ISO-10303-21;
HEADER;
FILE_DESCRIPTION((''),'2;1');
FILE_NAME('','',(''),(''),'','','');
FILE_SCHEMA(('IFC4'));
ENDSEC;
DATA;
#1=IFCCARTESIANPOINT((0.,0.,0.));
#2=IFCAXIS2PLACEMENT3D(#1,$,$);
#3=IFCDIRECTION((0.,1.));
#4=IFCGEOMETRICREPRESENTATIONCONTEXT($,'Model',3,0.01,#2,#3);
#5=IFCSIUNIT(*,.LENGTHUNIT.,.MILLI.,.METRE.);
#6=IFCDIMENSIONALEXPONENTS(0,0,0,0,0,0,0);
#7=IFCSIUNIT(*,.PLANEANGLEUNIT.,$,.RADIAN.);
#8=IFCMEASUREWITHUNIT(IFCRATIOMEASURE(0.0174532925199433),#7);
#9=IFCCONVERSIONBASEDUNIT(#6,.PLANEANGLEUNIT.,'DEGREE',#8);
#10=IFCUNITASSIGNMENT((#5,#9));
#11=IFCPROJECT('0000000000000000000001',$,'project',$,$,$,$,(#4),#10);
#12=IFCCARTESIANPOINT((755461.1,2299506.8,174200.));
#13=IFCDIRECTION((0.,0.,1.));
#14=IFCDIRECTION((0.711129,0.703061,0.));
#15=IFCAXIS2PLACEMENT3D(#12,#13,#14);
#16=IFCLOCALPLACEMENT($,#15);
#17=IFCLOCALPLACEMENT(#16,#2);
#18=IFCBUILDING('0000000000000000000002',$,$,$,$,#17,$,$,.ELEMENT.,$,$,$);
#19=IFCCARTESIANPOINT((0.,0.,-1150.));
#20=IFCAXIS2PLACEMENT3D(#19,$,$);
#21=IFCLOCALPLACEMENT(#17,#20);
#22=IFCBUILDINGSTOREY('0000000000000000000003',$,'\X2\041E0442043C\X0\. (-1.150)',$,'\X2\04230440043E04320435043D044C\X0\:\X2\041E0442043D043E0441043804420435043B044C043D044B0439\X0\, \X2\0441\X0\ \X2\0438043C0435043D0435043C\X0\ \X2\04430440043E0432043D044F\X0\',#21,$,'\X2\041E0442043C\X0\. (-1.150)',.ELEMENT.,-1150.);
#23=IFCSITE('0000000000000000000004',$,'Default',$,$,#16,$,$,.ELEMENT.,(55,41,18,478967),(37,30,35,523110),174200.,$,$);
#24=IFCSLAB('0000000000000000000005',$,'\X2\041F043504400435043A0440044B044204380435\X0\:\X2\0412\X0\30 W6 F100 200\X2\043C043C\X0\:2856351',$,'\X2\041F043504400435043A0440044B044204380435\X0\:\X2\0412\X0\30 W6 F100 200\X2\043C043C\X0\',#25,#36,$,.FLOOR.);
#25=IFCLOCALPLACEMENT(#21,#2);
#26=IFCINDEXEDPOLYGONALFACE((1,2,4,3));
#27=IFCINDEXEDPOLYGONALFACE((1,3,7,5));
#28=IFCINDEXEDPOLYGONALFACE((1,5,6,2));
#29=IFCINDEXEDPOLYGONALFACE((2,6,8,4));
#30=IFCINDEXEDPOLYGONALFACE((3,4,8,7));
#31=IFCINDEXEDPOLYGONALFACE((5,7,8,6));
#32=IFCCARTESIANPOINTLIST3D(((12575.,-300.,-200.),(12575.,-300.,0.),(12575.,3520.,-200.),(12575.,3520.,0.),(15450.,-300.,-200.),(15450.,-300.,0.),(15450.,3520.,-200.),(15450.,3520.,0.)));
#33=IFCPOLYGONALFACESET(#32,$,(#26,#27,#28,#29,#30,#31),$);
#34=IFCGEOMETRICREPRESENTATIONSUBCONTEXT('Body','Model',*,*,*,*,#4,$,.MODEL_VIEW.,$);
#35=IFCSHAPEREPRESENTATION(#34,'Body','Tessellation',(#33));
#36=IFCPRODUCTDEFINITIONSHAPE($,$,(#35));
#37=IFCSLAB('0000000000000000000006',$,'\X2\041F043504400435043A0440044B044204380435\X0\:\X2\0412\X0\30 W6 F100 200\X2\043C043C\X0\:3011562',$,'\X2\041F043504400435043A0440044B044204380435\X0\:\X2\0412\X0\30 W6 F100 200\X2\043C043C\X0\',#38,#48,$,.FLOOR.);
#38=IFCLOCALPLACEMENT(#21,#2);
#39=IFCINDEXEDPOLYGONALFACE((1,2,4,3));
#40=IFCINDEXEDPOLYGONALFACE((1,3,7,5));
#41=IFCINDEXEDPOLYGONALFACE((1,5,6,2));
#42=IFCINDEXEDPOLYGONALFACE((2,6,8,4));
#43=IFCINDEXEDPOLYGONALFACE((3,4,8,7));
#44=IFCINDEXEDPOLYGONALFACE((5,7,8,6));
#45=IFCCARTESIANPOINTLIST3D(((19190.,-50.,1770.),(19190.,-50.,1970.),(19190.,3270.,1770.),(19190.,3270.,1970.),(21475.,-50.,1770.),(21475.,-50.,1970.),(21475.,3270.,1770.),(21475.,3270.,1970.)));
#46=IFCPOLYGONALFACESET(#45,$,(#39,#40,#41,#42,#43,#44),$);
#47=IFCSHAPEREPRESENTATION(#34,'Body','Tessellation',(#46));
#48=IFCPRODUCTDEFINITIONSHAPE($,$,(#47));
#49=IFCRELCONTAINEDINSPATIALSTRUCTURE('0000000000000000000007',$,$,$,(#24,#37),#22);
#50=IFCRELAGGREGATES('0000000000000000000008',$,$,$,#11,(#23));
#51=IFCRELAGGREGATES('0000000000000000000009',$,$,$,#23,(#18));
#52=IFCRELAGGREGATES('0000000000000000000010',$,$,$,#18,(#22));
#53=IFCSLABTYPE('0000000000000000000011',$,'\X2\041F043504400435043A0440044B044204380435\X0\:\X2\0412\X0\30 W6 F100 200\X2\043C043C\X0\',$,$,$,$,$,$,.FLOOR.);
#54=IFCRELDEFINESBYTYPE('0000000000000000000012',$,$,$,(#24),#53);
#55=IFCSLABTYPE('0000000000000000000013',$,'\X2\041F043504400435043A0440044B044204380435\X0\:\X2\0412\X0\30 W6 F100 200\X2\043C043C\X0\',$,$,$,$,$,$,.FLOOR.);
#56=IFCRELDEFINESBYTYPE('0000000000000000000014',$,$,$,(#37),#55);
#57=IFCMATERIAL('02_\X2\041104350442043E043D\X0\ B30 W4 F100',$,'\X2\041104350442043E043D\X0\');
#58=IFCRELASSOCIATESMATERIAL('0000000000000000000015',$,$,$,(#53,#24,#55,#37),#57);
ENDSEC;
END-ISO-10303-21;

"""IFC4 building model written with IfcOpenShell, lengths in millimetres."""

from ifc_helpers import new_model, entity, si_unit, converted_unit, direction, frame, origin, place, context, subcontext, project, spatial, indexed_curve, outline, extrude, material, type_object, element, save


model = new_model("IFC4")

# Units and contexts
model_context = context("Model", 3, precision=0.01, world=origin(), true_north=direction((0.0, 1.0)))
body_context = subcontext(model_context, "Body", "Model", "MODEL_VIEW")
ifc_project = project(units=[si_unit("LENGTHUNIT", "METRE", prefix="MILLI"), converted_unit("PLANEANGLEUNIT", "DEGREE", entity("IfcRatioMeasure", 0.0174532925199433), si_unit("PLANEANGLEUNIT", "RADIAN"), dimensions=[0, 0, 0, 0, 0, 0, 0])], contexts=[model_context])

# Site, building, storey
site_placement = place(None, frame((755461.1, 2299506.8, 174200.0), z_axis=(0.0, 0.0, 1.0), x_axis=(0.711129, 0.703061, 0.0)))
site = spatial("IfcSite", under=ifc_project, at=site_placement, Name="Default", CompositionType="ELEMENT", RefLatitude=(55, 41, 18, 478967), RefLongitude=(37, 30, 35, 523110), RefElevation=174200.0)
building_placement = place(site_placement, origin())
building = spatial("IfcBuilding", under=site, at=building_placement, CompositionType="ELEMENT")
storey_placement = place(building_placement, frame((0.0, 0.0, -1150.0)))
storey = spatial("IfcBuildingStorey", under=building, at=storey_placement, Name="Отм. (-1.150)", ObjectType="Уровень:Относительный, с именем уровня", LongName="Отм. (-1.150)", CompositionType="ELEMENT", Elevation=-1150.0)

# Slabs
ifc_material_1 = material(Name="02_Бетон B30 W4 F100", Category="Бетон")
slab_type_1 = type_object("IfcSlabType", Name="Перекрытие:В30 W6 F100 200мм", PredefinedType="FLOOR", material=ifc_material_1)
slab_1_placement = place(storey_placement, origin())
element("IfcSlab", 1, at=slab_1_placement, inside=storey, type_object=slab_type_1, material=ifc_material_1, Name="Перекрытие:В30 W6 F100 200мм:2856351", ObjectType="Перекрытие:В30 W6 F100 200мм", PredefinedType="FLOOR", context=body_context, shape_type="SweptSolid", body=[
    extrude(outline(indexed_curve([(-1910.0, -1437.5), (1910.0, -1437.5), (1910.0, 1437.5), (-1910.0, 1437.5), (-1910.0, -1437.5)], self_intersect=False)), frame((14012.5, 1610.0, 0.0), z_axis=(0.0, 0.0, -1.0), x_axis=(0.0, 1.0, 0.0)), (0.0, 0.0, 1.0), 200.0),
])
slab_type_2 = type_object("IfcSlabType", Name="Перекрытие:В30 W6 F100 200мм", PredefinedType="FLOOR", material=ifc_material_1)
slab_2_placement = place(storey_placement, origin())
element("IfcSlab", 2, at=slab_2_placement, inside=storey, type_object=slab_type_2, material=ifc_material_1, Name="Перекрытие:В30 W6 F100 200мм:3011562", ObjectType="Перекрытие:В30 W6 F100 200мм", PredefinedType="FLOOR", context=body_context, shape_type="SweptSolid", body=[
    extrude(outline(indexed_curve([(-1660.0, -1142.5), (1660.0, -1142.5), (1660.0, 1142.5), (-1660.0, 1142.5), (-1660.0, -1142.5)], self_intersect=False)), frame((20332.5, 1610.0, 1970.0), z_axis=(0.0, 0.0, -1.0), x_axis=(0.0, 1.0, 0.0)), (0.0, 0.0, 1.0), 200.0),
])

save(model, "model.ifc")
